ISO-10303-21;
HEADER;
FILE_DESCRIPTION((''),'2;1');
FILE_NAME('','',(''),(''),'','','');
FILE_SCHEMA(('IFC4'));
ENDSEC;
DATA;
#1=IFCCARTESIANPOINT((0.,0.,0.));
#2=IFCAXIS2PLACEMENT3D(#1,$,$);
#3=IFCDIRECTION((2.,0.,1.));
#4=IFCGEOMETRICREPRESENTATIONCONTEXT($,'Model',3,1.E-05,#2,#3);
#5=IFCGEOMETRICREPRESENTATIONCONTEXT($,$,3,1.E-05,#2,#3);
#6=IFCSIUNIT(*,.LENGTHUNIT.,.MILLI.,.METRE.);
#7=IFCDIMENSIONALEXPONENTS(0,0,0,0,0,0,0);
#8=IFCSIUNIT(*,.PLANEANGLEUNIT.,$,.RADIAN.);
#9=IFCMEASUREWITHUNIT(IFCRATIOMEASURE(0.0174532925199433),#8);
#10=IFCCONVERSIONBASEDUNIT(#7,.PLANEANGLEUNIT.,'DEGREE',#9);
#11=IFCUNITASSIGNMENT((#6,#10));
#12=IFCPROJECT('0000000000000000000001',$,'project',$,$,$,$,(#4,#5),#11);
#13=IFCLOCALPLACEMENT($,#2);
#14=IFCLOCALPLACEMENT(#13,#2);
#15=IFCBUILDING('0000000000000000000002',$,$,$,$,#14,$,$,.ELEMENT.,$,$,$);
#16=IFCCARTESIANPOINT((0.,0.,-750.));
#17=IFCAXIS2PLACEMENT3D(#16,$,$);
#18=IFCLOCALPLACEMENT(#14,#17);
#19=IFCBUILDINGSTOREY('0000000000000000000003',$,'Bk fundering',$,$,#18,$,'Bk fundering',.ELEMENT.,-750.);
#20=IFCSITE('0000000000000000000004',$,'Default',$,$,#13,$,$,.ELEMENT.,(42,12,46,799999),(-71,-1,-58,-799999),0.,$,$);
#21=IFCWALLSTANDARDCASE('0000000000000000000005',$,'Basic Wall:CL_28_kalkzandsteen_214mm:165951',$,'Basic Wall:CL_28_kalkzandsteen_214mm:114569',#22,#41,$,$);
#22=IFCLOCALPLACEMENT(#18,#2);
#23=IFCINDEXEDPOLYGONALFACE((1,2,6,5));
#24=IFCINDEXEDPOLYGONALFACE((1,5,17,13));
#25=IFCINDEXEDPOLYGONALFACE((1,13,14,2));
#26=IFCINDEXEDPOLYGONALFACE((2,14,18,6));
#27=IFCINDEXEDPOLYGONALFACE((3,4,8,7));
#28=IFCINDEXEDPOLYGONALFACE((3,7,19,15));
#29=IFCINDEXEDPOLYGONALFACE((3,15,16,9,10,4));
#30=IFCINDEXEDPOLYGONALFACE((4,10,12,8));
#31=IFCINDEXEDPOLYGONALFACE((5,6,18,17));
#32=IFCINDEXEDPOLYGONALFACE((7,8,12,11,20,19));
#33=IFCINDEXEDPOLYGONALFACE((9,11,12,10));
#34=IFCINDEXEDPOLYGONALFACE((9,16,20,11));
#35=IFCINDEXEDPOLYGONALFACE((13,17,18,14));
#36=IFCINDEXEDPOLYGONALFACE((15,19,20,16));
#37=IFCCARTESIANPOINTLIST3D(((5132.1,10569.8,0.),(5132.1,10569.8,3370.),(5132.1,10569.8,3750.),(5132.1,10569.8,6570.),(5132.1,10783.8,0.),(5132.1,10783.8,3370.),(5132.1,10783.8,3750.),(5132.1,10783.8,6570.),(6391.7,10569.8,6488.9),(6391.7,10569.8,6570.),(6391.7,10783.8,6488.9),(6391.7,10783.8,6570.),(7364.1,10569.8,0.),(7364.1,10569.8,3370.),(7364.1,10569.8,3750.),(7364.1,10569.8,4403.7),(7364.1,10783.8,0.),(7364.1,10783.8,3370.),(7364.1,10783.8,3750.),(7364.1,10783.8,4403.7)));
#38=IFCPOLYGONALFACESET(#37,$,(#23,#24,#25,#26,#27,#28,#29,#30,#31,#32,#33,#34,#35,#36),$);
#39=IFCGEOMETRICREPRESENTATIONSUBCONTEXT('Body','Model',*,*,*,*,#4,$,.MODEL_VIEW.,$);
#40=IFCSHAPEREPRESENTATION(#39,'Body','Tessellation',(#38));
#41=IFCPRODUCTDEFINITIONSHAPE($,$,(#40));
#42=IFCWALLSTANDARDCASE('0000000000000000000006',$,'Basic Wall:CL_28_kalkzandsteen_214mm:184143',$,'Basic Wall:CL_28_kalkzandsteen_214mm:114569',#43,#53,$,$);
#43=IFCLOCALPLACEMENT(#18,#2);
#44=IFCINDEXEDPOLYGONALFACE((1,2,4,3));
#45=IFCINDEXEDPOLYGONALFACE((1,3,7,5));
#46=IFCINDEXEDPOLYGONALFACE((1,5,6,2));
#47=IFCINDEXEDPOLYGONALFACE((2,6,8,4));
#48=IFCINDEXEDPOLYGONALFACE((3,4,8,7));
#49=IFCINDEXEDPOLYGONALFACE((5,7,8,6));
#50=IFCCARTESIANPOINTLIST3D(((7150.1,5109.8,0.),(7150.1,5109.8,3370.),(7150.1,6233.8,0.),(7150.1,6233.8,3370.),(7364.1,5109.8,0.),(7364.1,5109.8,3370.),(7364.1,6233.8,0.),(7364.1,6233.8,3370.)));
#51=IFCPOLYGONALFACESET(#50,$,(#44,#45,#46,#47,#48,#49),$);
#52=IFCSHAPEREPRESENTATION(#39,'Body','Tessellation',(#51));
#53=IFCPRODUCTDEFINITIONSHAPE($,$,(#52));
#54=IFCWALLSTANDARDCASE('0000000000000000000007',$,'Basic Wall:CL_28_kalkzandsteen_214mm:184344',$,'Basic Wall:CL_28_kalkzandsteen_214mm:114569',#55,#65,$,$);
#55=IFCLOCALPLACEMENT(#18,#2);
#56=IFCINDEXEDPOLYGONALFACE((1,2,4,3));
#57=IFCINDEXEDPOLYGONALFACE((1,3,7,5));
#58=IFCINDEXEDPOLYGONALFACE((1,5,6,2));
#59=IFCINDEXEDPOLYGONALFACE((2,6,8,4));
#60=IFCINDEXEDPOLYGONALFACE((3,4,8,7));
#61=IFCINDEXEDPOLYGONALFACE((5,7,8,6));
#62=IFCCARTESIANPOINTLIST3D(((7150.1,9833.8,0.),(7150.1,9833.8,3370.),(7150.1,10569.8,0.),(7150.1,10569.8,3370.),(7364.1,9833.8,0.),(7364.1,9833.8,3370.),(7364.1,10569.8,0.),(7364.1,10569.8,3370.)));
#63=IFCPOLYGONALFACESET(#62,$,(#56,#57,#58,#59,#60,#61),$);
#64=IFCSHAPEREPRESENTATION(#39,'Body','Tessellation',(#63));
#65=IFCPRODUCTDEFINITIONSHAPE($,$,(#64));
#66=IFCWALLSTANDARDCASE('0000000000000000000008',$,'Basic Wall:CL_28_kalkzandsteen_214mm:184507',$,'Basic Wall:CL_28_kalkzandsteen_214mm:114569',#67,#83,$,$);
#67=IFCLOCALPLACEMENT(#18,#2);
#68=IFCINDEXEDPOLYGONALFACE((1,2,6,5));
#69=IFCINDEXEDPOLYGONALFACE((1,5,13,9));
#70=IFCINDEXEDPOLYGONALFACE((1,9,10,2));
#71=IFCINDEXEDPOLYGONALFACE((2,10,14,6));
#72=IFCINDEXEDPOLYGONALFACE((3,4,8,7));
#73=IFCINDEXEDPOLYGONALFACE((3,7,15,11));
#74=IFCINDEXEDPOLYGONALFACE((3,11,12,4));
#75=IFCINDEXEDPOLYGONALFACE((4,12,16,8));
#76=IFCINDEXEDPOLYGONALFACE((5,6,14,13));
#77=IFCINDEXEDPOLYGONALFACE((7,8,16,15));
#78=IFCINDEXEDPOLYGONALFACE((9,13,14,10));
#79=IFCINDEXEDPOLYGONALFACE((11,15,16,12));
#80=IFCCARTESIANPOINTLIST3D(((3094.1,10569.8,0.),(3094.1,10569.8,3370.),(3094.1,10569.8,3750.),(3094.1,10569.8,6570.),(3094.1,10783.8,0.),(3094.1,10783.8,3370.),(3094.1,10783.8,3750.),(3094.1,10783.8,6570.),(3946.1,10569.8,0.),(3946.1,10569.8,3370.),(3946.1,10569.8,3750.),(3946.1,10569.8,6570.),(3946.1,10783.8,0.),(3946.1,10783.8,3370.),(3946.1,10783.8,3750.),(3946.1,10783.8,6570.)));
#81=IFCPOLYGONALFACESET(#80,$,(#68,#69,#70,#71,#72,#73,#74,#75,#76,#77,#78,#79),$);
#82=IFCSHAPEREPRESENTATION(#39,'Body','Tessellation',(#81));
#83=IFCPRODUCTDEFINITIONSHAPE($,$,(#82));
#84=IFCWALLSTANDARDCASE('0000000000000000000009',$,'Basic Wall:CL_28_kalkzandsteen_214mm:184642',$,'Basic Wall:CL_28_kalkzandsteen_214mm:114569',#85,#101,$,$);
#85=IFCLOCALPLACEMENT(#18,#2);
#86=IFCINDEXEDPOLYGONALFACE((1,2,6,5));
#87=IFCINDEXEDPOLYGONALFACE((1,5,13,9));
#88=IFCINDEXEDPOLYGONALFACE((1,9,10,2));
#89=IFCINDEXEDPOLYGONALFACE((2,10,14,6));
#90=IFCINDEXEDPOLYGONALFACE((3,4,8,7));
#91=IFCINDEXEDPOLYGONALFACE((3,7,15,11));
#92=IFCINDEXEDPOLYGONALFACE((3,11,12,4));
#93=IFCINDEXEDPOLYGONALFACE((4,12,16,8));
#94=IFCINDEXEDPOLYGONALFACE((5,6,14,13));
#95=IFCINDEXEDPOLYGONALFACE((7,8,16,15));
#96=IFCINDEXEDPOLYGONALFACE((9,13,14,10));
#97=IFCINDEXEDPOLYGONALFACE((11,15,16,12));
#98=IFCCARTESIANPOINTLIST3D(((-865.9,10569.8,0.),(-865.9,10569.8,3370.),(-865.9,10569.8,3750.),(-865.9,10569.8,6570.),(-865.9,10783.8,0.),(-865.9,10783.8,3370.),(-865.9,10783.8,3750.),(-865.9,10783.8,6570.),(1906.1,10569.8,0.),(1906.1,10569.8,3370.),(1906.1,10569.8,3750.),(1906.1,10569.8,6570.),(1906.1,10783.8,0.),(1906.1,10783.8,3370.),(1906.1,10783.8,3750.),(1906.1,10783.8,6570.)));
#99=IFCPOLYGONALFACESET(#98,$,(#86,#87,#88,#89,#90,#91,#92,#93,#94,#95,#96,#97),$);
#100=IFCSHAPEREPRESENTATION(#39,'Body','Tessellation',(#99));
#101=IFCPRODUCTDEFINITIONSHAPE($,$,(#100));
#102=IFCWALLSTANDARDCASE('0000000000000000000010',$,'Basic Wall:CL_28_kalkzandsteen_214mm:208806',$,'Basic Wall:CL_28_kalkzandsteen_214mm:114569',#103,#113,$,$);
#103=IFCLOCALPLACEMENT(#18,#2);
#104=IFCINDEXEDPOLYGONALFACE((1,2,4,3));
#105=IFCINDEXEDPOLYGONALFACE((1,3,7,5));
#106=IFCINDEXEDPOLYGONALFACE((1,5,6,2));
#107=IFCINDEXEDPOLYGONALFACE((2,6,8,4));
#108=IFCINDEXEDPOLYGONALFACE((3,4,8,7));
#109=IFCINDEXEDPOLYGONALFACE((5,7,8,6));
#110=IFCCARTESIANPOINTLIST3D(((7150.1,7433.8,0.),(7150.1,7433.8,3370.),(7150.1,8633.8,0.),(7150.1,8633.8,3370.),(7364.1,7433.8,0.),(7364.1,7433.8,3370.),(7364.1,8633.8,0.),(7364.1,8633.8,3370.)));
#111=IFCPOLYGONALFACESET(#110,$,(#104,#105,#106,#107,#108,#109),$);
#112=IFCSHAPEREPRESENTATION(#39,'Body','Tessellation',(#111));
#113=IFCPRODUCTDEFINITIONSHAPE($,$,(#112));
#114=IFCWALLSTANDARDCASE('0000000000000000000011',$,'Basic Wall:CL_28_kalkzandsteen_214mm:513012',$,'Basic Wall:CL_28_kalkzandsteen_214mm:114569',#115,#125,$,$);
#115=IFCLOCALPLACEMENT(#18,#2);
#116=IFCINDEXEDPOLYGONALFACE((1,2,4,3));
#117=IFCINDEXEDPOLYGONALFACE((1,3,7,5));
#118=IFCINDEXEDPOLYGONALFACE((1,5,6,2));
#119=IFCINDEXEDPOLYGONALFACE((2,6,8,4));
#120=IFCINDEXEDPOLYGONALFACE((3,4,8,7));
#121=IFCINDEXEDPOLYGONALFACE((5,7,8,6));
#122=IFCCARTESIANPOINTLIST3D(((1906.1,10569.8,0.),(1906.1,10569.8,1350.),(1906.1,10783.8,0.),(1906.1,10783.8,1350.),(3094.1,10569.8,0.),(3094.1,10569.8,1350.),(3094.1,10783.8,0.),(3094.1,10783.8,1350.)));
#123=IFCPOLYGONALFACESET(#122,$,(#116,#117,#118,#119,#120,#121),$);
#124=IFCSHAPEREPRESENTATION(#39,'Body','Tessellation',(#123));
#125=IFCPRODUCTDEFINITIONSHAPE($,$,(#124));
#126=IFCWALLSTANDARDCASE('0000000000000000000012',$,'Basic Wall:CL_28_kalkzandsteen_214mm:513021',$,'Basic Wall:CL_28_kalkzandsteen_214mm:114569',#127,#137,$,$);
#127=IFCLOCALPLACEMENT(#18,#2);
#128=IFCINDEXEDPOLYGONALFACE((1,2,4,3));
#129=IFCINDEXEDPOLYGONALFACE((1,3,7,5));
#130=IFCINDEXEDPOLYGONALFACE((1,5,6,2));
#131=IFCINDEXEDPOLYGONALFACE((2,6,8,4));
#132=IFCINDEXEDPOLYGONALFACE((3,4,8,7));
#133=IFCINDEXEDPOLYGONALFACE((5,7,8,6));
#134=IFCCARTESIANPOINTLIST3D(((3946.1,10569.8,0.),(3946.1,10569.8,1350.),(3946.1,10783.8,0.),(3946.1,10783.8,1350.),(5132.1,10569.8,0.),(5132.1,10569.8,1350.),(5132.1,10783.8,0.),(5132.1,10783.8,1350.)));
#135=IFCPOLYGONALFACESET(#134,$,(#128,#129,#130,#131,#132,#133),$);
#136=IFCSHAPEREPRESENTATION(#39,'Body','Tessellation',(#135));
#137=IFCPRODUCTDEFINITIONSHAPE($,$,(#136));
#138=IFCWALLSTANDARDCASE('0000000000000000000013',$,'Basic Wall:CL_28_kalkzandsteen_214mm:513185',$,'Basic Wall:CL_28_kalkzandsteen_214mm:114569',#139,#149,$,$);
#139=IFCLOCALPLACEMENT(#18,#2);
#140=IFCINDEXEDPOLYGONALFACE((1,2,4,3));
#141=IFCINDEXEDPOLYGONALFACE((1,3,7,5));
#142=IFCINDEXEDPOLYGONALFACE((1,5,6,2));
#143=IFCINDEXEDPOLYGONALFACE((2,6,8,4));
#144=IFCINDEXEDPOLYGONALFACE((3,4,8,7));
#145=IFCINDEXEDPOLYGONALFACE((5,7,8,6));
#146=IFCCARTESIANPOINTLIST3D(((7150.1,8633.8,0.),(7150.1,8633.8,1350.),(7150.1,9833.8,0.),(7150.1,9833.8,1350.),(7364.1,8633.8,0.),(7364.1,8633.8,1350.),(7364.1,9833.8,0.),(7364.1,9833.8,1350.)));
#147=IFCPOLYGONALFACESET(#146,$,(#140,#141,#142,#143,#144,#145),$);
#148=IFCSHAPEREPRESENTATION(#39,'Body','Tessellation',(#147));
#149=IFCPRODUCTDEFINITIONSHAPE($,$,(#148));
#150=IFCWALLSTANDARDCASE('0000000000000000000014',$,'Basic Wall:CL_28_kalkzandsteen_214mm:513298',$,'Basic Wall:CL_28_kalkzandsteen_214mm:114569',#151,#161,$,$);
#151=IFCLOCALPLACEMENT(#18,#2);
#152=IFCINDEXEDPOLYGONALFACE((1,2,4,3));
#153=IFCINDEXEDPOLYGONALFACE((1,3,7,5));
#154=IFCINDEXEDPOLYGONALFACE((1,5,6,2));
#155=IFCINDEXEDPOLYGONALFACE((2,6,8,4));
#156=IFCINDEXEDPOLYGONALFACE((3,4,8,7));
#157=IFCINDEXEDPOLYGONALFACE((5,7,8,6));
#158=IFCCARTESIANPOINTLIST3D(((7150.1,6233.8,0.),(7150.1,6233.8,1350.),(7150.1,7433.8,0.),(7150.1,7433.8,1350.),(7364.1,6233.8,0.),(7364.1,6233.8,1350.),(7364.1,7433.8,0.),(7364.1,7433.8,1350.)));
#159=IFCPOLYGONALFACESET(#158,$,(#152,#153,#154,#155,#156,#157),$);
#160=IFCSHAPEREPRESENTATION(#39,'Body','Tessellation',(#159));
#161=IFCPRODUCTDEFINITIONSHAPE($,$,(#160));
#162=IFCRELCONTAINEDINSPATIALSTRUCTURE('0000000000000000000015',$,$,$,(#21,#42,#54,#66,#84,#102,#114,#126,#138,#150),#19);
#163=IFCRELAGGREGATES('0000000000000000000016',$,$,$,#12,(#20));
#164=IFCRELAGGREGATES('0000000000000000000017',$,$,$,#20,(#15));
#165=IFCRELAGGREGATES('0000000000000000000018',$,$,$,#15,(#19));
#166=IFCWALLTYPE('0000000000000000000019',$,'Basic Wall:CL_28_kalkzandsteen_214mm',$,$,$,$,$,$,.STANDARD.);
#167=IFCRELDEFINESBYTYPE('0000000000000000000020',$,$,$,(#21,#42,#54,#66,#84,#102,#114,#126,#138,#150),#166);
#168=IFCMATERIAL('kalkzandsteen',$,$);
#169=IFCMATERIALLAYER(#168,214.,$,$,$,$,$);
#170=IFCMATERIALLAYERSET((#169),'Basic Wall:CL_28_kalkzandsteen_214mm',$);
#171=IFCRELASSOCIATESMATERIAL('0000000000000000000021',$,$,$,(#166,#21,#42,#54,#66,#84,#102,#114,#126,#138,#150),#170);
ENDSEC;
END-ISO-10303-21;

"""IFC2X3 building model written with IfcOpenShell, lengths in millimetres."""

from ifc_helpers import new_model, entity, si_unit, converted_unit, direction, frame, frame_2d, origin, origin_2d_with_axis, place, context, subcontext, project, spatial, polyline, rectangle, extrude, clip, bounded_halfspace, material, layer, layer_set, layer_usage, type_object, element, save


model = new_model("IFC2X3")

# Units and contexts
model_context = context("Model", 3, precision=1e-05, world=origin(), true_north=direction((2.0, 0.0, 1.0)))
context_of_model = context(None, 3, precision=1e-05, world=origin(), true_north=direction((2.0, 0.0, 1.0)))
body_context = subcontext(model_context, "Body", "Model", "MODEL_VIEW")
ifc_project = project(units=[si_unit("LENGTHUNIT", "METRE", prefix="MILLI"), converted_unit("PLANEANGLEUNIT", "DEGREE", entity("IfcRatioMeasure", 0.0174532925199433), si_unit("PLANEANGLEUNIT", "RADIAN"), dimensions=[0, 0, 0, 0, 0, 0, 0])], contexts=[model_context, context_of_model])

# Site, building, storey
site_placement = place(None, origin())
site = spatial("IfcSite", under=ifc_project, at=site_placement, Name="Default", CompositionType="ELEMENT", RefLatitude=(42, 12, 46, 799999), RefLongitude=(-71, -1, -58, -799999), RefElevation=0.0)
building_placement = place(site_placement, origin())
building = spatial("IfcBuilding", under=site, at=building_placement, CompositionType="ELEMENT")
storey_placement = place(building_placement, frame((0.0, 0.0, -750.0)))
storey = spatial("IfcBuildingStorey", under=building, at=storey_placement, Name="Bk fundering", LongName="Bk fundering", CompositionType="ELEMENT", Elevation=-750.0)

# Wall, opening
ifc_material_1 = material(Name="kalkzandsteen")
ifc_layer_1 = layer(ifc_material_1, 214.0)
ifc_layer_set_1 = layer_set([ifc_layer_1], Name="Basic Wall:CL_28_kalkzandsteen_214mm")
ifc_layer_usage_1 = layer_usage(ifc_layer_set_1, "AXIS2", "NEGATIVE", 107.0)
wall_type_1 = type_object("IfcWallType", Name="Basic Wall:CL_28_kalkzandsteen_214mm", PredefinedType="STANDARD", material=ifc_layer_set_1)
wall_1_placement = place(storey_placement, frame((7364.1, 10676.8, 0.0), z_axis=(0.0, 0.0, 1.0), x_axis=(-1.0, 0.0, 0.0)))
wall_1 = element("IfcWallStandardCase", 1, at=wall_1_placement, inside=storey, type_object=wall_type_1, material=ifc_layer_usage_1, Name="Basic Wall:CL_28_kalkzandsteen_214mm:165951", ObjectType="Basic Wall:CL_28_kalkzandsteen_214mm:114569", context=body_context, shape_type="Clipping", body=[
    clip(extrude(rectangle(XDim=2232.0, YDim=214.0, at=frame_2d((1116.0, 0.0), x_axis=(-1.0, 0.0))), origin(), (0.0, 0.0, 1.0), 6570.0), bounded_halfspace(frame((0.0, -107.0, 4403.7), z_axis=(-0.906308, 0.0, 0.422618), x_axis=(0.0, -1.0, 0.0)), False, frame((0.0, -107.0, 4403.7)), polyline([(0.0, 0.0), (972.3, 0.0), (972.3, 214.0), (0.0, 214.0), (0.0, 0.0)]))),
])
opening_1_placement = place(storey_placement, frame((7364.1, 10676.8, 0.0), z_axis=(0.0, 0.0, 1.0), x_axis=(-1.0, 0.0, 0.0)))
element("IfcOpeningElement", 2, at=opening_1_placement, cuts=wall_1, ObjectType="Opening", context=body_context, shape_type="SweptSolid", body=[
    extrude(rectangle(XDim=2232.0, YDim=214.0, at=frame_2d((180.4, -21.4), x_axis=(1.0, 0.0))), frame((935.6, 21.4, 3370.0)), (0.0, 0.0, 1.0), 380.0),
])

# Walls
ifc_layer_usage_2 = layer_usage(ifc_layer_set_1, "AXIS2", "NEGATIVE", 107.0)
wall_2_placement = place(storey_placement, frame((7257.1, 5109.8, 0.0), z_axis=(0.0, 0.0, 1.0), x_axis=(0.0, 1.0, 0.0)))
element("IfcWallStandardCase", 3, at=wall_2_placement, inside=storey, type_object=wall_type_1, material=ifc_layer_usage_2, Name="Basic Wall:CL_28_kalkzandsteen_214mm:184143", ObjectType="Basic Wall:CL_28_kalkzandsteen_214mm:114569", context=body_context, shape_type="Clipping", body=[
    clip(extrude(rectangle(XDim=1124.0, YDim=214.0, at=frame_2d((562.0, 0.0), x_axis=(-1.0, 0.0))), origin(), (0.0, 0.0, 1.0), 3750.0), bounded_halfspace(frame((0.0, -107.0, 3370.0), z_axis=(0.0, 0.0, -1.0), x_axis=(0.0, -1.0, 0.0)), True, frame((0.0, -107.0, 3370.0), z_axis=(0.0, 0.0, -1.0), x_axis=(0.0, -1.0, 0.0)), polyline([(0.0, 0.0), (-214.0, 0.0), (-214.0, -1124.0), (0.0, -1124.0), (0.0, 0.0)]))),
])
ifc_layer_usage_3 = layer_usage(ifc_layer_set_1, "AXIS2", "NEGATIVE", 107.0)
wall_3_placement = place(storey_placement, frame((7257.1, 9833.8, 0.0), z_axis=(0.0, 0.0, 1.0), x_axis=(0.0, 1.0, 0.0)))
element("IfcWallStandardCase", 4, at=wall_3_placement, inside=storey, type_object=wall_type_1, material=ifc_layer_usage_3, Name="Basic Wall:CL_28_kalkzandsteen_214mm:184344", ObjectType="Basic Wall:CL_28_kalkzandsteen_214mm:114569", context=body_context, shape_type="Clipping", body=[
    clip(extrude(rectangle(XDim=736.0, YDim=214.0, at=frame_2d((368.0, 0.0), x_axis=(-1.0, 0.0))), origin(), (0.0, 0.0, 1.0), 3750.0), bounded_halfspace(frame((0.0, -107.0, 3370.0), z_axis=(0.0, 0.0, -1.0), x_axis=(0.0, -1.0, 0.0)), True, frame((0.0, -107.0, 3370.0), z_axis=(0.0, 0.0, -1.0), x_axis=(0.0, -1.0, 0.0)), polyline([(0.0, 0.0), (-214.0, 0.0), (-214.0, -736.0), (0.0, -736.0), (0.0, 0.0)]))),
])

# Walls, openings
ifc_layer_usage_4 = layer_usage(ifc_layer_set_1, "AXIS2", "NEGATIVE", 107.0)
wall_4_placement = place(storey_placement, frame((3946.1, 10676.8, 0.0), z_axis=(0.0, 0.0, 1.0), x_axis=(-1.0, 0.0, 0.0)))
wall_4 = element("IfcWallStandardCase", 5, at=wall_4_placement, inside=storey, type_object=wall_type_1, material=ifc_layer_usage_4, Name="Basic Wall:CL_28_kalkzandsteen_214mm:184507", ObjectType="Basic Wall:CL_28_kalkzandsteen_214mm:114569", context=body_context, shape_type="SweptSolid", body=[
    extrude(rectangle(XDim=852.0, YDim=214.0, at=frame_2d((426.0, 0.0), x_axis=(-1.0, 0.0))), origin(), (0.0, 0.0, 1.0), 6570.0),
])
opening_2_placement = place(storey_placement, frame((3946.1, 10676.8, 0.0), z_axis=(0.0, 0.0, 1.0), x_axis=(-1.0, 0.0, 0.0)))
element("IfcOpeningElement", 6, at=opening_2_placement, cuts=wall_4, ObjectType="Opening", context=body_context, shape_type="SweptSolid", body=[
    extrude(rectangle(XDim=852.0, YDim=214.0, at=origin_2d_with_axis()), frame((426.0, 0.0, 3370.0)), (0.0, 0.0, 1.0), 380.0),
])
ifc_layer_usage_5 = layer_usage(ifc_layer_set_1, "AXIS2", "NEGATIVE", 107.0)
wall_5_placement = place(storey_placement, frame((1906.1, 10676.8, 0.0), z_axis=(0.0, 0.0, 1.0), x_axis=(-1.0, 0.0, 0.0)))
wall_5 = element("IfcWallStandardCase", 7, at=wall_5_placement, inside=storey, type_object=wall_type_1, material=ifc_layer_usage_5, Name="Basic Wall:CL_28_kalkzandsteen_214mm:184642", ObjectType="Basic Wall:CL_28_kalkzandsteen_214mm:114569", context=body_context, shape_type="SweptSolid", body=[
    extrude(rectangle(XDim=2772.0, YDim=214.0, at=frame_2d((1386.0, 0.0), x_axis=(-1.0, 0.0))), origin(), (0.0, 0.0, 1.0), 6570.0),
])
opening_3_placement = place(storey_placement, frame((1906.1, 10676.8, 0.0), z_axis=(0.0, 0.0, 1.0), x_axis=(-1.0, 0.0, 0.0)))
element("IfcOpeningElement", 8, at=opening_3_placement, cuts=wall_5, ObjectType="Opening", context=body_context, shape_type="SweptSolid", body=[
    extrude(rectangle(XDim=2772.0, YDim=214.0, at=origin_2d_with_axis()), frame((1386.0, 0.0, 3370.0)), (0.0, 0.0, 1.0), 380.0),
])

# Walls
ifc_layer_usage_6 = layer_usage(ifc_layer_set_1, "AXIS2", "NEGATIVE", 107.0)
wall_6_placement = place(storey_placement, frame((7257.1, 7433.8, 0.0), z_axis=(0.0, 0.0, 1.0), x_axis=(0.0, 1.0, 0.0)))
element("IfcWallStandardCase", 9, at=wall_6_placement, inside=storey, type_object=wall_type_1, material=ifc_layer_usage_6, Name="Basic Wall:CL_28_kalkzandsteen_214mm:208806", ObjectType="Basic Wall:CL_28_kalkzandsteen_214mm:114569", context=body_context, shape_type="Clipping", body=[
    clip(extrude(rectangle(XDim=1200.0, YDim=214.0, at=frame_2d((600.0, 0.0), x_axis=(-1.0, 0.0))), origin(), (0.0, 0.0, 1.0), 3750.0), bounded_halfspace(frame((0.0, -107.0, 3370.0), z_axis=(0.0, 0.0, -1.0), x_axis=(0.0, -1.0, 0.0)), True, frame((0.0, -107.0, 3370.0), z_axis=(0.0, 0.0, -1.0), x_axis=(0.0, -1.0, 0.0)), polyline([(0.0, 0.0), (-214.0, 0.0), (-214.0, -1200.0), (0.0, -1200.0), (0.0, 0.0)]))),
])
ifc_layer_usage_7 = layer_usage(ifc_layer_set_1, "AXIS2", "NEGATIVE", 107.0)
wall_7_placement = place(storey_placement, frame((3094.1, 10676.8, 0.0), z_axis=(0.0, 0.0, 1.0), x_axis=(-1.0, 0.0, 0.0)))
element("IfcWallStandardCase", 10, at=wall_7_placement, inside=storey, type_object=wall_type_1, material=ifc_layer_usage_7, Name="Basic Wall:CL_28_kalkzandsteen_214mm:513012", ObjectType="Basic Wall:CL_28_kalkzandsteen_214mm:114569", context=body_context, shape_type="SweptSolid", body=[
    extrude(rectangle(XDim=1188.0, YDim=214.0, at=frame_2d((594.0, 0.0), x_axis=(-1.0, 0.0))), origin(), (0.0, 0.0, 1.0), 1350.0),
])
ifc_layer_usage_8 = layer_usage(ifc_layer_set_1, "AXIS2", "NEGATIVE", 107.0)
wall_8_placement = place(storey_placement, frame((5132.1, 10676.8, 0.0), z_axis=(0.0, 0.0, 1.0), x_axis=(-1.0, 0.0, 0.0)))
element("IfcWallStandardCase", 11, at=wall_8_placement, inside=storey, type_object=wall_type_1, material=ifc_layer_usage_8, Name="Basic Wall:CL_28_kalkzandsteen_214mm:513021", ObjectType="Basic Wall:CL_28_kalkzandsteen_214mm:114569", context=body_context, shape_type="SweptSolid", body=[
    extrude(rectangle(XDim=1186.0, YDim=214.0, at=frame_2d((593.0, 0.0), x_axis=(-1.0, 0.0))), origin(), (0.0, 0.0, 1.0), 1350.0),
])
ifc_layer_usage_9 = layer_usage(ifc_layer_set_1, "AXIS2", "NEGATIVE", 107.0)
wall_9_placement = place(storey_placement, frame((7257.1, 9833.8, 0.0), z_axis=(0.0, 0.0, 1.0), x_axis=(0.0, -1.0, 0.0)))
element("IfcWallStandardCase", 12, at=wall_9_placement, inside=storey, type_object=wall_type_1, material=ifc_layer_usage_9, Name="Basic Wall:CL_28_kalkzandsteen_214mm:513185", ObjectType="Basic Wall:CL_28_kalkzandsteen_214mm:114569", context=body_context, shape_type="SweptSolid", body=[
    extrude(rectangle(XDim=1200.0, YDim=214.0, at=frame_2d((600.0, 0.0), x_axis=(-1.0, 0.0))), origin(), (0.0, 0.0, 1.0), 1350.0),
])
ifc_layer_usage_10 = layer_usage(ifc_layer_set_1, "AXIS2", "NEGATIVE", 107.0)
wall_10_placement = place(storey_placement, frame((7257.1, 7433.8, 0.0), z_axis=(0.0, 0.0, 1.0), x_axis=(0.0, -1.0, 0.0)))
element("IfcWallStandardCase", 13, at=wall_10_placement, inside=storey, type_object=wall_type_1, material=ifc_layer_usage_10, Name="Basic Wall:CL_28_kalkzandsteen_214mm:513298", ObjectType="Basic Wall:CL_28_kalkzandsteen_214mm:114569", context=body_context, shape_type="SweptSolid", body=[
    extrude(rectangle(XDim=1200.0, YDim=214.0, at=frame_2d((600.0, 0.0), x_axis=(-1.0, 0.0))), origin(), (0.0, 0.0, 1.0), 1350.0),
])

save(model, "model.ifc")
